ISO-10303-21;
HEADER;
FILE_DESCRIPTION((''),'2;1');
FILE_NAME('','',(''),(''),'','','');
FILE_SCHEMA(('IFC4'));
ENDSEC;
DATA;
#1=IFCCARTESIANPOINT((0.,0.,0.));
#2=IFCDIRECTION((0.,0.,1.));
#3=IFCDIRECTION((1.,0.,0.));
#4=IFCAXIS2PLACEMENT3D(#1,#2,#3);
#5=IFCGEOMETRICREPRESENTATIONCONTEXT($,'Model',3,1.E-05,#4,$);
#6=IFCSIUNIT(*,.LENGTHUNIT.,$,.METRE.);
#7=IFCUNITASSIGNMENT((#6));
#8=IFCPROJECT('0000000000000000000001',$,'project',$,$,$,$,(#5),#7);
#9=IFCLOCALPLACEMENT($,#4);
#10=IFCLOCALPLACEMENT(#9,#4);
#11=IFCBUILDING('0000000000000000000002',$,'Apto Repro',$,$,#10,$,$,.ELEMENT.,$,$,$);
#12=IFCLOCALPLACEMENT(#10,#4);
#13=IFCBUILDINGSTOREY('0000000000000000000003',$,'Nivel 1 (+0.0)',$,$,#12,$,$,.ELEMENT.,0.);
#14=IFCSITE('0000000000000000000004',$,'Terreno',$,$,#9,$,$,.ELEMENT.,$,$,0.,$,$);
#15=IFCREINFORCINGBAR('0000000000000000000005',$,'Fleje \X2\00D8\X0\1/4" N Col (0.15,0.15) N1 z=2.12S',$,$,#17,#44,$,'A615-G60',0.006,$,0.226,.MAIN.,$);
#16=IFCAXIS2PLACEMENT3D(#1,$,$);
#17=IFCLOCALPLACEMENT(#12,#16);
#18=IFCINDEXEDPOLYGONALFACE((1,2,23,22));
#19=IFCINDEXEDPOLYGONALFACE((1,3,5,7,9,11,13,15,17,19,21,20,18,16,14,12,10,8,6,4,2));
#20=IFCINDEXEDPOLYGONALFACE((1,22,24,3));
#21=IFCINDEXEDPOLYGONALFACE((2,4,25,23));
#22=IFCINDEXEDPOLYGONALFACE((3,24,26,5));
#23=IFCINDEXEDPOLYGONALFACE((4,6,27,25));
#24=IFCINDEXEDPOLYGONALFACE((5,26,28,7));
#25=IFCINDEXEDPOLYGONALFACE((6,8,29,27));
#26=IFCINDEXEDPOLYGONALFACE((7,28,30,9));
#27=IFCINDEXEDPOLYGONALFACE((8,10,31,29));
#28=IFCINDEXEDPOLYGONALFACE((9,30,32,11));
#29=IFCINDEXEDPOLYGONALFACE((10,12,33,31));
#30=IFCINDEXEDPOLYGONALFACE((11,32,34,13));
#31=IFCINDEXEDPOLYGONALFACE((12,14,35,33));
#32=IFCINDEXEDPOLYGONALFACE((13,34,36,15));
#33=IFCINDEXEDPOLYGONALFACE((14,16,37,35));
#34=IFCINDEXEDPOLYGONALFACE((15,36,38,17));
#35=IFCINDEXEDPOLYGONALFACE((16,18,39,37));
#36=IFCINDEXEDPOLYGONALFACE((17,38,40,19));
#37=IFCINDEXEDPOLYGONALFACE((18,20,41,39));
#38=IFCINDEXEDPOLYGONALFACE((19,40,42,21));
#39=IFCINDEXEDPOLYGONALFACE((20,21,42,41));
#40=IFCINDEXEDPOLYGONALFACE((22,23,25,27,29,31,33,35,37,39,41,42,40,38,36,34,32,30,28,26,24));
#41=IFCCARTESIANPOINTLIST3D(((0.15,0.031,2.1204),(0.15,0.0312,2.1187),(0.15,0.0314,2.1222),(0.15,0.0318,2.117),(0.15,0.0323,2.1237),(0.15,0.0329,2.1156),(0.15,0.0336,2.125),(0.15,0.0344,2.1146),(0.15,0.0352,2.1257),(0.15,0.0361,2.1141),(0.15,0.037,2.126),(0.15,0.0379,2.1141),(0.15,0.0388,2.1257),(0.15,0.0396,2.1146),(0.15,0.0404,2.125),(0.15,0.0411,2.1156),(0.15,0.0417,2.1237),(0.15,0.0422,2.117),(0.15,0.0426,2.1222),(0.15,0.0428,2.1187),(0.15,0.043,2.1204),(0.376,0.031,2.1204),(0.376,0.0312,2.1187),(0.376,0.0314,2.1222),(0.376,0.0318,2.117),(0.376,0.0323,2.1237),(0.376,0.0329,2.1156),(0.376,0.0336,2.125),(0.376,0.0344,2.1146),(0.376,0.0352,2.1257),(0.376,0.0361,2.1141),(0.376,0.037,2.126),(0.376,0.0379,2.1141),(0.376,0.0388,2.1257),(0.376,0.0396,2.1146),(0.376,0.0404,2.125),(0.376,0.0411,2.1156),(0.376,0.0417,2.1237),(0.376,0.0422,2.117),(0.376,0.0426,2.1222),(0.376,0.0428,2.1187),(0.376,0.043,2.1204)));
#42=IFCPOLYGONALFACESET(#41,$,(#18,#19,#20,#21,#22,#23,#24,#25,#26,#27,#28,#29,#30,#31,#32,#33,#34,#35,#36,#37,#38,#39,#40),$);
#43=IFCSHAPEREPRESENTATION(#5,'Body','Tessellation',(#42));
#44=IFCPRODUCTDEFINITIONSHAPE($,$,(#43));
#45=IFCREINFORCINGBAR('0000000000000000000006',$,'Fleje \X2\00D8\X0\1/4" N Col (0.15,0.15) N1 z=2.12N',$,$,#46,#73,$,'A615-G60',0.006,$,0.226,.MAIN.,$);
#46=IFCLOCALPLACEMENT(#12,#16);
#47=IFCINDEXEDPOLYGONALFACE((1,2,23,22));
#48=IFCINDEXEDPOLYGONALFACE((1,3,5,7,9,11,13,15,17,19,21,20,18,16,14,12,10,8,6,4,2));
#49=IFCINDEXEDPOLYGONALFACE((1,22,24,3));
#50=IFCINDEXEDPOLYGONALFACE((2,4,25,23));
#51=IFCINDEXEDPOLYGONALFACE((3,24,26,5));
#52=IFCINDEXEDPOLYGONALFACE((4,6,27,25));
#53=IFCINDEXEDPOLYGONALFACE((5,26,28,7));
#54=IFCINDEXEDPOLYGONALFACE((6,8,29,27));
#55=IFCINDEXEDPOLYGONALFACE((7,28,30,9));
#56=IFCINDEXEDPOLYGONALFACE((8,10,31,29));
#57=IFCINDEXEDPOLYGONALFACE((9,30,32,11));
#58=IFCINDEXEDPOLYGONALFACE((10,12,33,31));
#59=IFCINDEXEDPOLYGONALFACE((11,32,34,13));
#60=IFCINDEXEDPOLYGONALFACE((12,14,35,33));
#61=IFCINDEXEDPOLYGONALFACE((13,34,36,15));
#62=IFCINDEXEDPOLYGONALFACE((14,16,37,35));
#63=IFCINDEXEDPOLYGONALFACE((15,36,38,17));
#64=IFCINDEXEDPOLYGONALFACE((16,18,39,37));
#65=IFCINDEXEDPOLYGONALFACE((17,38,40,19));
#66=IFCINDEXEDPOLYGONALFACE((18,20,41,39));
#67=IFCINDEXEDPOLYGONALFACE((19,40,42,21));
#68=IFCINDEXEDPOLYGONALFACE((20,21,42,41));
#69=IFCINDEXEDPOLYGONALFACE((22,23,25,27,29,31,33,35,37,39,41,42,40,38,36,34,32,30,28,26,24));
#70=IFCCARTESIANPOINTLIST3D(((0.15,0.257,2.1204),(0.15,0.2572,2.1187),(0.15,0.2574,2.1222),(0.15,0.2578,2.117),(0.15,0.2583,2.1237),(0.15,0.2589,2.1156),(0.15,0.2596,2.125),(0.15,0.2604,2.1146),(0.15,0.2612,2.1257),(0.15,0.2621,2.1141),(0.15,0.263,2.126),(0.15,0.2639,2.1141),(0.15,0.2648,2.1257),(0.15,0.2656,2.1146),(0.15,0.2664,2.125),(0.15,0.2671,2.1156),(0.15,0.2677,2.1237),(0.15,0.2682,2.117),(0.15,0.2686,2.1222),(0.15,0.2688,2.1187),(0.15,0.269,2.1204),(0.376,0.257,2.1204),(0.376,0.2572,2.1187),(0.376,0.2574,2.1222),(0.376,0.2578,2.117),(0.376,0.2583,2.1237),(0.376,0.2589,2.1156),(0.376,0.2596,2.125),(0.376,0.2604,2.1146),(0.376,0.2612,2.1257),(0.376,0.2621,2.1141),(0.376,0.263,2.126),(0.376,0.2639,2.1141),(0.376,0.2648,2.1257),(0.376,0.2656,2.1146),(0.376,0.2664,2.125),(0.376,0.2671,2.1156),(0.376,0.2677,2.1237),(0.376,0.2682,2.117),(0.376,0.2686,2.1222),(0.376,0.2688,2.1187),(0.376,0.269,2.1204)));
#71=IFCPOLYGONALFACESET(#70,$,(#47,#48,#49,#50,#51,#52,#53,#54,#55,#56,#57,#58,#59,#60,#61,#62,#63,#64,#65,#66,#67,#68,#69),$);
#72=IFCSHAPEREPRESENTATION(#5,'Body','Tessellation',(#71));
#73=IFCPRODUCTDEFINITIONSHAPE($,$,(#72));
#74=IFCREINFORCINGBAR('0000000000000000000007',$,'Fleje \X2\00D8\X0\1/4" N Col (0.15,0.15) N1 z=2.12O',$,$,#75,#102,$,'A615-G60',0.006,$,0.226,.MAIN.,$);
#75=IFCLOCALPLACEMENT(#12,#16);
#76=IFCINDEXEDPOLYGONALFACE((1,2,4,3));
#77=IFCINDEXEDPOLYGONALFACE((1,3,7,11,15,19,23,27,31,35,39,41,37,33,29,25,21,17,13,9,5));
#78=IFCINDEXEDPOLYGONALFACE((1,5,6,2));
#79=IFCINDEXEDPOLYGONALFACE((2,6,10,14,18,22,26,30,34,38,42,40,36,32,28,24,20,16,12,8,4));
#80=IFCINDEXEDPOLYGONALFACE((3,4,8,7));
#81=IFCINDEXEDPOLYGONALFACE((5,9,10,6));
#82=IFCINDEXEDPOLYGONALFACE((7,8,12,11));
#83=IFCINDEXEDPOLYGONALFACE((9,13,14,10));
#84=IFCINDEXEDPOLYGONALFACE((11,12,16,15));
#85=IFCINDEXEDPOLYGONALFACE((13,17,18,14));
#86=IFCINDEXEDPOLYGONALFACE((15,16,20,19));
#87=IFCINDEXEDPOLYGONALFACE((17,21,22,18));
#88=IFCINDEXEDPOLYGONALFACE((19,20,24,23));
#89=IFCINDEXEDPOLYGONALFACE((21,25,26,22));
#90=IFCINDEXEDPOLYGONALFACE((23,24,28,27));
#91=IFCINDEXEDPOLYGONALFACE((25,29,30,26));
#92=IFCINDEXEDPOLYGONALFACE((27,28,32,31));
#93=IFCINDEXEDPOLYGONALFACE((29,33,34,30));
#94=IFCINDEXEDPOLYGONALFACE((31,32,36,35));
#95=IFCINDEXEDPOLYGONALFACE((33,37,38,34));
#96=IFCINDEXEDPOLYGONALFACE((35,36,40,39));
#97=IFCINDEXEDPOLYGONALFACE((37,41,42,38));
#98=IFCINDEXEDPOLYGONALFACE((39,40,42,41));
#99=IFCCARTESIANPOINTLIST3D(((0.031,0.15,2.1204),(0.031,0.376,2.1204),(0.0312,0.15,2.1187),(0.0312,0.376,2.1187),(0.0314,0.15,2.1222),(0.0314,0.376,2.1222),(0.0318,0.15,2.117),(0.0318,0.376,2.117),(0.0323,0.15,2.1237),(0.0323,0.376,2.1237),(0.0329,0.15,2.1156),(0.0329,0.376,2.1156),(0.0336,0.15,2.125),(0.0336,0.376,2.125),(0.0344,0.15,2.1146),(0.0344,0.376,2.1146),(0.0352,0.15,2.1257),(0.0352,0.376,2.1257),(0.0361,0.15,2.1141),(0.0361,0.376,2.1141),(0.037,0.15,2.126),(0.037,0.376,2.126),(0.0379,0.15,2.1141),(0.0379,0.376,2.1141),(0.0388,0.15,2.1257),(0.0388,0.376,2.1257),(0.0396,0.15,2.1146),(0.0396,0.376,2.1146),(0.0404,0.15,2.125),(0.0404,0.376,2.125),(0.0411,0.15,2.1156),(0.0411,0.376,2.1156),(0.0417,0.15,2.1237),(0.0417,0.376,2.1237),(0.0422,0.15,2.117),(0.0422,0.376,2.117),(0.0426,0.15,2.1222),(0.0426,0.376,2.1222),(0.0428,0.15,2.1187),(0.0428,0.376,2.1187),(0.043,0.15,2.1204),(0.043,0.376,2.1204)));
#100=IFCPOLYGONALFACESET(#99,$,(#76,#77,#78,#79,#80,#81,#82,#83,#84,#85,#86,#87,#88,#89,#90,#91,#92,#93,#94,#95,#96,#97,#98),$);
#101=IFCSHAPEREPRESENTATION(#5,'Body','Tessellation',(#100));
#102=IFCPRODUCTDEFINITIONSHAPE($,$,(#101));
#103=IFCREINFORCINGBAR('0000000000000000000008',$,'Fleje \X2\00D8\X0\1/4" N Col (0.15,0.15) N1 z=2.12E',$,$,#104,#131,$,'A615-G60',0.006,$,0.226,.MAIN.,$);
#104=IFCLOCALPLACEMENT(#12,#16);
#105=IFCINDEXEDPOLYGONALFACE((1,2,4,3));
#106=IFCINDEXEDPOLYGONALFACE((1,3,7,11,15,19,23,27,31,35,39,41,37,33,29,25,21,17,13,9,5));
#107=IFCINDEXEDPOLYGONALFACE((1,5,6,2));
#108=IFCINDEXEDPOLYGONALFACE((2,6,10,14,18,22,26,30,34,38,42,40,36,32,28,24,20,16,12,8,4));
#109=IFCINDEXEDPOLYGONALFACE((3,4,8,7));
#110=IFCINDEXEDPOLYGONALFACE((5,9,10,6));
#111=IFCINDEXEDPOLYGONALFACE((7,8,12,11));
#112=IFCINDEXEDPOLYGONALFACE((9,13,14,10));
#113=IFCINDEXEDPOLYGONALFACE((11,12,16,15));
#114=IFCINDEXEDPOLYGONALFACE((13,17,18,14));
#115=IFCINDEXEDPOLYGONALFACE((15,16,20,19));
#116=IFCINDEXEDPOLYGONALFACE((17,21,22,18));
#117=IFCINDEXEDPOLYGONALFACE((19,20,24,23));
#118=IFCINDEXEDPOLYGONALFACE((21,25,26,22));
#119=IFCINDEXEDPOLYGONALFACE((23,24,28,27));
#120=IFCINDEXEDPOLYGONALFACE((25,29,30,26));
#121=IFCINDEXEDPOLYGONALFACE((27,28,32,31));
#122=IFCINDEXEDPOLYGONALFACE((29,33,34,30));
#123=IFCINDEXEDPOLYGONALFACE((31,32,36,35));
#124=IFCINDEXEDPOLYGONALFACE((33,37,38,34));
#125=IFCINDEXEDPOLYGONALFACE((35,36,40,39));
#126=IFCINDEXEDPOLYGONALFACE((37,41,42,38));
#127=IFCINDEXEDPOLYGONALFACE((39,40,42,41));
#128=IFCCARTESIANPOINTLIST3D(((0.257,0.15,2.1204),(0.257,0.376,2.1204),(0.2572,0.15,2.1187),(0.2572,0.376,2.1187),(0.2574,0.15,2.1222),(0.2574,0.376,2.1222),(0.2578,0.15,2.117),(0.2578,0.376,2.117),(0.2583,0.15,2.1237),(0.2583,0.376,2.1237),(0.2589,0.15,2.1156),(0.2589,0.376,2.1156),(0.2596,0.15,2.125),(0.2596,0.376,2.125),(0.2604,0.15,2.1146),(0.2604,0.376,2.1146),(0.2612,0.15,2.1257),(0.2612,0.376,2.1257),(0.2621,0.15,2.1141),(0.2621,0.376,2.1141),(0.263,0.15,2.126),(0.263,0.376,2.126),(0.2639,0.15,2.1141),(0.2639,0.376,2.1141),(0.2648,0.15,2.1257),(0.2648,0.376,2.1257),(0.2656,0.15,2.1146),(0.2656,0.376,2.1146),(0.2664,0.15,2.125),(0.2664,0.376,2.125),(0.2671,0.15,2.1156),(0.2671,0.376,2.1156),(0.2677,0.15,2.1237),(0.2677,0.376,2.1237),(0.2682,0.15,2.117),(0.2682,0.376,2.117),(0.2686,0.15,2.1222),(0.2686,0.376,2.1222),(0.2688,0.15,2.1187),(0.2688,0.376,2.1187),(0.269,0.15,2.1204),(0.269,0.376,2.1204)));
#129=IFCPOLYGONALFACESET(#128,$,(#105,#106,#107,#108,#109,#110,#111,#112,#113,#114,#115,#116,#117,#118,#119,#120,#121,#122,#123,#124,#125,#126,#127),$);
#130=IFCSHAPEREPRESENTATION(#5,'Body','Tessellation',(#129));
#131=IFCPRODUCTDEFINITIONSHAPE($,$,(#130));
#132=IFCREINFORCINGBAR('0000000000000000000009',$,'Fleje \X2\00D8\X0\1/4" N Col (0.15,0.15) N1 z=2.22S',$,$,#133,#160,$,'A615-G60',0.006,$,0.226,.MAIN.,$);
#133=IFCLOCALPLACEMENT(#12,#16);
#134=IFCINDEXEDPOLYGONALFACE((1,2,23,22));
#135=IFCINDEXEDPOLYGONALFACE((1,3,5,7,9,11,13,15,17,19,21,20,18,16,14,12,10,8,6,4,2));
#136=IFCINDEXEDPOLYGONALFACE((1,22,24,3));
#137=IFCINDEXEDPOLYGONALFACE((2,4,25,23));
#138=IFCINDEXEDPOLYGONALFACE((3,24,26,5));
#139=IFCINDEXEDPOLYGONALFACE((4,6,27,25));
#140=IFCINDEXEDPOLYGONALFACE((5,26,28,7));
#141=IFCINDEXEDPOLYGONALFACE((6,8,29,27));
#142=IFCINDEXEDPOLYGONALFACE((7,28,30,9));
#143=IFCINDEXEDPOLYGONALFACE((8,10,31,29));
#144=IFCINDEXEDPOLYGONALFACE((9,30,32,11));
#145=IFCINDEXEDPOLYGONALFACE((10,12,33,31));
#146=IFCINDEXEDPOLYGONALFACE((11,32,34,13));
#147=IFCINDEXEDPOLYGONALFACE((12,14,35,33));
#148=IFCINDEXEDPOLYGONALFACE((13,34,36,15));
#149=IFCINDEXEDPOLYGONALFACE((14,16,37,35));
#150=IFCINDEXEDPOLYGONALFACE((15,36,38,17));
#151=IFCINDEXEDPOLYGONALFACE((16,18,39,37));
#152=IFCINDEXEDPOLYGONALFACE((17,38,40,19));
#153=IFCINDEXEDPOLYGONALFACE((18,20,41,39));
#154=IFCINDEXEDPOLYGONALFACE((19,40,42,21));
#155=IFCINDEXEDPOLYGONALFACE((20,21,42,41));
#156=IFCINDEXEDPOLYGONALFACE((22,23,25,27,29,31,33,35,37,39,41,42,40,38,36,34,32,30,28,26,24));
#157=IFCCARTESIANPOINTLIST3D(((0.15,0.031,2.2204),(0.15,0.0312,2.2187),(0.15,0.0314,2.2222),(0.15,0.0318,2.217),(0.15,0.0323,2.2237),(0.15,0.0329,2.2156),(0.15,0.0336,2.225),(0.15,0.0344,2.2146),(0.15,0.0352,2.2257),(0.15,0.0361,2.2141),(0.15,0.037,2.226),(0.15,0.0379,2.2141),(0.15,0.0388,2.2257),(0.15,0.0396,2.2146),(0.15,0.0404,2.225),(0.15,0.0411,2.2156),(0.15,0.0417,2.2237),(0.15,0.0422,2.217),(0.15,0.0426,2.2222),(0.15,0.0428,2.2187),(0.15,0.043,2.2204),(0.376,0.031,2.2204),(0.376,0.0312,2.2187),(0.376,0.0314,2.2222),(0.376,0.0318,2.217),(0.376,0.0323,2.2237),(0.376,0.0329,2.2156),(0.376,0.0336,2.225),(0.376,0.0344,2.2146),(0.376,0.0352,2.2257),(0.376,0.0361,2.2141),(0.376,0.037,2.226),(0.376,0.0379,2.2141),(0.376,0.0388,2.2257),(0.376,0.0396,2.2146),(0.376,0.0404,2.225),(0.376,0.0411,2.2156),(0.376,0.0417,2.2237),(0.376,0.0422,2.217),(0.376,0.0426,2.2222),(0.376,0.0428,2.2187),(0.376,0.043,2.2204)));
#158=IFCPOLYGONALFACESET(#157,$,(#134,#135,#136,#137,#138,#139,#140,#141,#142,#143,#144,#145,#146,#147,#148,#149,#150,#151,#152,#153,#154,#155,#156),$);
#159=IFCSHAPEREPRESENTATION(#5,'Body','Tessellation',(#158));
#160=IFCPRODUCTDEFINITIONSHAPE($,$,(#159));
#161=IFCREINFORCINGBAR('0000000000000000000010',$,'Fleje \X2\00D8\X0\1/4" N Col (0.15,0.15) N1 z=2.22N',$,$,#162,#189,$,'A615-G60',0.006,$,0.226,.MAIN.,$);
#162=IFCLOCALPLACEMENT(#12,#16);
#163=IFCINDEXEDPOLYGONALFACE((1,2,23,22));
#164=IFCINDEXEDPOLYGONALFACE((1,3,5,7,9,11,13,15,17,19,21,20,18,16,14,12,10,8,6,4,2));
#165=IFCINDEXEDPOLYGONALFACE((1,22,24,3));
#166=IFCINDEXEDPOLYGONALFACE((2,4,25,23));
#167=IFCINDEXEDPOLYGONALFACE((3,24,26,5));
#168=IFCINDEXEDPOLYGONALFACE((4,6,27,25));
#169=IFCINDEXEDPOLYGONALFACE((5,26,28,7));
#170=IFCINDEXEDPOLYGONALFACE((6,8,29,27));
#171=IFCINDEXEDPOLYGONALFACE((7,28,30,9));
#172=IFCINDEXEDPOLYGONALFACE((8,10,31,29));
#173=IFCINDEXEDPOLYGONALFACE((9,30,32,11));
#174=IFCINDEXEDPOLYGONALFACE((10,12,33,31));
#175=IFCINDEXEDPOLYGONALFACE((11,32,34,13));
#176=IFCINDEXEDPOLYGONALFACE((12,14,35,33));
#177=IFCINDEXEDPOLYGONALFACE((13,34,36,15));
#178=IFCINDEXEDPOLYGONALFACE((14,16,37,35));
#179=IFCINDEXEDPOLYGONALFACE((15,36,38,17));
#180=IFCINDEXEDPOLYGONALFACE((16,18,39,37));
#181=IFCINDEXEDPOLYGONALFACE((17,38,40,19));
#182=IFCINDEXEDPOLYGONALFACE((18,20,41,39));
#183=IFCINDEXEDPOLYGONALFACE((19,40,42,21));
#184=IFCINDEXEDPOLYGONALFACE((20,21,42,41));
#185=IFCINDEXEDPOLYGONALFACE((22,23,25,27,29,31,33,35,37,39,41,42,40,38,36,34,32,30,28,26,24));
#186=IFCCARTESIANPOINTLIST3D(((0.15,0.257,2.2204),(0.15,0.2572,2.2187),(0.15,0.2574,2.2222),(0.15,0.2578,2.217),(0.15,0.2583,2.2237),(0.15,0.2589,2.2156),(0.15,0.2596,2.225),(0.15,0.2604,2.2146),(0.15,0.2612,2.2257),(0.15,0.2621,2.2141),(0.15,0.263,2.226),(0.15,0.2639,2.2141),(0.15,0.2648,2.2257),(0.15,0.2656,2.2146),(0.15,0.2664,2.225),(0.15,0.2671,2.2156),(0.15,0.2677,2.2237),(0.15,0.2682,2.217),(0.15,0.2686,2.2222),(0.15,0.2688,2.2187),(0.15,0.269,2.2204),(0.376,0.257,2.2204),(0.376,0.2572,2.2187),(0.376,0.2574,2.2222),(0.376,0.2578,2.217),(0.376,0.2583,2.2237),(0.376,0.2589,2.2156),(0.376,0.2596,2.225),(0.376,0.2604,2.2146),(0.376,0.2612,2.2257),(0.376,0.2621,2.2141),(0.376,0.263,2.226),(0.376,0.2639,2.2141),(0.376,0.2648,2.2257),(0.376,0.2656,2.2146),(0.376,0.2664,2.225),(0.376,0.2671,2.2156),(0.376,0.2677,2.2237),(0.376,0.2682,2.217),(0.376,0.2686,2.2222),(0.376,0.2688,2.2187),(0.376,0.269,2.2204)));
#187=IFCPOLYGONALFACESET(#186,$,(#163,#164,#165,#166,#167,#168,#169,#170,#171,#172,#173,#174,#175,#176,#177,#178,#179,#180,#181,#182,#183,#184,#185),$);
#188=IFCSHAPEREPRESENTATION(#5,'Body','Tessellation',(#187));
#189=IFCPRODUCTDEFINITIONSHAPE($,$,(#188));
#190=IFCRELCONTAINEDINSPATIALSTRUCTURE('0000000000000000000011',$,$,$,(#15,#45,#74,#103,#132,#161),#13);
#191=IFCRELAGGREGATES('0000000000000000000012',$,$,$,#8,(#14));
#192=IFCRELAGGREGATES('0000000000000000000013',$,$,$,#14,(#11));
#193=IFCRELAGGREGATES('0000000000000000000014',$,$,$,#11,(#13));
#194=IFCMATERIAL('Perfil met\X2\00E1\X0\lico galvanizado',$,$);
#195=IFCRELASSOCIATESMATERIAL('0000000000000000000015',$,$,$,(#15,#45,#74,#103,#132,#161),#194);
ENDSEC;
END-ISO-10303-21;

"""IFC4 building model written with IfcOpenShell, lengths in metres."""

from ifc_helpers import new_model, si_unit, frame, origin_with_axes, origin_2d_with_axis, place, context, project, spatial, circle, extrude, material, element, save


model = new_model("IFC4")

# Units and contexts
model_context = context("Model", 3, precision=1e-05, world=origin_with_axes())
ifc_project = project(units=[si_unit("LENGTHUNIT", "METRE")], contexts=[model_context])

# Site, building, storey
site_placement = place(None, origin_with_axes())
site = spatial("IfcSite", under=ifc_project, at=site_placement, Name="Terreno", CompositionType="ELEMENT", RefElevation=0.0)
building_placement = place(site_placement, origin_with_axes())
building = spatial("IfcBuilding", under=site, at=building_placement, Name="Apto Repro", CompositionType="ELEMENT")
storey_placement = place(building_placement, origin_with_axes())
storey = spatial("IfcBuildingStorey", under=building, at=storey_placement, Name="Nivel 1 (+0.0)", CompositionType="ELEMENT", Elevation=0.0)

# Reinforcing bars
ifc_material = material(Name="Perfil metálico galvanizado")
reinforcing_bar_1_placement = place(storey_placement, origin_with_axes())
element("IfcReinforcingBar", 1, at=reinforcing_bar_1_placement, inside=storey, material=ifc_material, Name="Fleje Ø1/4\" N Col (0.15,0.15) N1 z=2.12S", SteelGrade="A615-G60", BarLength=0.226, NominalDiameter=0.006, PredefinedType="MAIN", context=model_context, shape_type="SweptSolid", body=[
    extrude(circle(Radius=0.006, at=origin_2d_with_axis()), frame((0.15, 0.037, 2.12), z_axis=(1.0, 0.0, 0.0), x_axis=(0.0, 0.0, 1.0)), (0.0, 0.0, 1.0), 0.226),
])
reinforcing_bar_2_placement = place(storey_placement, origin_with_axes())
element("IfcReinforcingBar", 2, at=reinforcing_bar_2_placement, inside=storey, material=ifc_material, Name="Fleje Ø1/4\" N Col (0.15,0.15) N1 z=2.12N", SteelGrade="A615-G60", BarLength=0.226, NominalDiameter=0.006, PredefinedType="MAIN", context=model_context, shape_type="SweptSolid", body=[
    extrude(circle(Radius=0.006, at=origin_2d_with_axis()), frame((0.15, 0.263, 2.12), z_axis=(1.0, 0.0, 0.0), x_axis=(0.0, 0.0, 1.0)), (0.0, 0.0, 1.0), 0.226),
])
reinforcing_bar_3_placement = place(storey_placement, origin_with_axes())
element("IfcReinforcingBar", 3, at=reinforcing_bar_3_placement, inside=storey, material=ifc_material, Name="Fleje Ø1/4\" N Col (0.15,0.15) N1 z=2.12O", SteelGrade="A615-G60", BarLength=0.226, NominalDiameter=0.006, PredefinedType="MAIN", context=model_context, shape_type="SweptSolid", body=[
    extrude(circle(Radius=0.006, at=origin_2d_with_axis()), frame((0.037, 0.15, 2.12), z_axis=(0.0, 1.0, 0.0), x_axis=(0.0, 0.0, 1.0)), (0.0, 0.0, 1.0), 0.226),
])
reinforcing_bar_4_placement = place(storey_placement, origin_with_axes())
element("IfcReinforcingBar", 4, at=reinforcing_bar_4_placement, inside=storey, material=ifc_material, Name="Fleje Ø1/4\" N Col (0.15,0.15) N1 z=2.12E", SteelGrade="A615-G60", BarLength=0.226, NominalDiameter=0.006, PredefinedType="MAIN", context=model_context, shape_type="SweptSolid", body=[
    extrude(circle(Radius=0.006, at=origin_2d_with_axis()), frame((0.263, 0.15, 2.12), z_axis=(0.0, 1.0, 0.0), x_axis=(0.0, 0.0, 1.0)), (0.0, 0.0, 1.0), 0.226),
])
reinforcing_bar_5_placement = place(storey_placement, origin_with_axes())
element("IfcReinforcingBar", 5, at=reinforcing_bar_5_placement, inside=storey, material=ifc_material, Name="Fleje Ø1/4\" N Col (0.15,0.15) N1 z=2.22S", SteelGrade="A615-G60", BarLength=0.226, NominalDiameter=0.006, PredefinedType="MAIN", context=model_context, shape_type="SweptSolid", body=[
    extrude(circle(Radius=0.006, at=origin_2d_with_axis()), frame((0.15, 0.037, 2.22), z_axis=(1.0, 0.0, 0.0), x_axis=(0.0, 0.0, 1.0)), (0.0, 0.0, 1.0), 0.226),
])
reinforcing_bar_6_placement = place(storey_placement, origin_with_axes())
element("IfcReinforcingBar", 6, at=reinforcing_bar_6_placement, inside=storey, material=ifc_material, Name="Fleje Ø1/4\" N Col (0.15,0.15) N1 z=2.22N", SteelGrade="A615-G60", BarLength=0.226, NominalDiameter=0.006, PredefinedType="MAIN", context=model_context, shape_type="SweptSolid", body=[
    extrude(circle(Radius=0.006, at=origin_2d_with_axis()), frame((0.15, 0.263, 2.22), z_axis=(1.0, 0.0, 0.0), x_axis=(0.0, 0.0, 1.0)), (0.0, 0.0, 1.0), 0.226),
])

save(model, "model.ifc")
